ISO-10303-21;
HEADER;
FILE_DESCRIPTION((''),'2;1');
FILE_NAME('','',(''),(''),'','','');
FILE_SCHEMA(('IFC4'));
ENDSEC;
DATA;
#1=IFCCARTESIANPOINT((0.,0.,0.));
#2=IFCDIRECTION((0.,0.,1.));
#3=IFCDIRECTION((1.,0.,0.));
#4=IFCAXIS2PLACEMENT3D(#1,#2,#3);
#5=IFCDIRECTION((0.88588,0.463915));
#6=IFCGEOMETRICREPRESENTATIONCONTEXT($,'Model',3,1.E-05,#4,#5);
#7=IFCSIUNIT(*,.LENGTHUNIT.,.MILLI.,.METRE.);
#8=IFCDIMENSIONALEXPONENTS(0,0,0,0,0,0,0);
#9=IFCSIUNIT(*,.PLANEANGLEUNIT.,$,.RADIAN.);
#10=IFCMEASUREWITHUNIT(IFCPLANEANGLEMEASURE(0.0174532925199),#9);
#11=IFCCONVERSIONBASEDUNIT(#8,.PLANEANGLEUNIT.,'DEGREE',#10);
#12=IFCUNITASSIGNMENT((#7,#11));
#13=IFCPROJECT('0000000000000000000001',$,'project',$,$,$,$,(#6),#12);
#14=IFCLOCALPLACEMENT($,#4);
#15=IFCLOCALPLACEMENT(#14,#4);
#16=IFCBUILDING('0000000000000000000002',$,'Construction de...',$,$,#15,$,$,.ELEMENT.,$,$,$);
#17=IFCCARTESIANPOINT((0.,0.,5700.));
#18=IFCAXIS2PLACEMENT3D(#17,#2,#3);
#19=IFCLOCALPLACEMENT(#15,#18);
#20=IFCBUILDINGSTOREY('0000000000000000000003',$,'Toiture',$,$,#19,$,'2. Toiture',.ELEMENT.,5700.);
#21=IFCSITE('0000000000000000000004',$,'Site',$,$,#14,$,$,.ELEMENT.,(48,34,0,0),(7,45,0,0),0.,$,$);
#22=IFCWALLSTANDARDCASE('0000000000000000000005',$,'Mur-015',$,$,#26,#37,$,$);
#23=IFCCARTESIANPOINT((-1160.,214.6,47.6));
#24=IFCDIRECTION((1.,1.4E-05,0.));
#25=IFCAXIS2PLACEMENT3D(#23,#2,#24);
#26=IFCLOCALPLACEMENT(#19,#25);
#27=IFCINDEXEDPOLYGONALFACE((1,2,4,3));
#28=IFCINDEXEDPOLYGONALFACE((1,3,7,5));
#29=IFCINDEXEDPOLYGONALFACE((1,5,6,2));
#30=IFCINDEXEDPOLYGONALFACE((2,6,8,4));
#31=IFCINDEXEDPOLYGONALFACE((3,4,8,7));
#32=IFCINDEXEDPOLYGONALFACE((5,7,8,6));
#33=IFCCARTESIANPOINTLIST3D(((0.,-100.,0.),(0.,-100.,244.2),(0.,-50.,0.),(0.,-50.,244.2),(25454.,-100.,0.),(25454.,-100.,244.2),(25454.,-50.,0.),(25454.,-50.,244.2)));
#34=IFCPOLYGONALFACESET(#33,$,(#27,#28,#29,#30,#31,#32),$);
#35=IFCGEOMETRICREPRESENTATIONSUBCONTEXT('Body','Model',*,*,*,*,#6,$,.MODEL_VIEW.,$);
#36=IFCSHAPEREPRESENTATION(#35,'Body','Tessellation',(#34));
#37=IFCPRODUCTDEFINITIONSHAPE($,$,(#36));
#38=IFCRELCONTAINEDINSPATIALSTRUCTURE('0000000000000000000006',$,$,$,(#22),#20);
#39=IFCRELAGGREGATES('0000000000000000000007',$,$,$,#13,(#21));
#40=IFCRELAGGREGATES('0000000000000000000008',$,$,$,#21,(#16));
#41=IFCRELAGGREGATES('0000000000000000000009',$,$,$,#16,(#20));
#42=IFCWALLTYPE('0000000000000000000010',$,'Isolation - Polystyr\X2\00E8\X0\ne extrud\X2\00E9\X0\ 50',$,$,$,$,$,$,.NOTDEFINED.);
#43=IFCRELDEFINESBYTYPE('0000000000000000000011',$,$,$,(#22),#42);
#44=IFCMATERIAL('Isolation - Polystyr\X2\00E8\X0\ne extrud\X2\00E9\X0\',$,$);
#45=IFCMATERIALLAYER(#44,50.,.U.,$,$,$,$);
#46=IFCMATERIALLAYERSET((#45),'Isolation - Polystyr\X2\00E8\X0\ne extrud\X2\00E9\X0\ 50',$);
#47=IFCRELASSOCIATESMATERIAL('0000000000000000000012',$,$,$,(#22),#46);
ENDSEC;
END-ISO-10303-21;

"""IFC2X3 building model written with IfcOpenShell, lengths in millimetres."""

from ifc_helpers import new_model, entity, si_unit, converted_unit, direction, frame, origin_with_axes, place, context, subcontext, project, spatial, polyline, outline, extrude, material, layer, layer_set, layer_usage, type_object, element, save


model = new_model("IFC2X3")

# Units and contexts
model_context = context("Model", 3, precision=1e-05, world=origin_with_axes(), true_north=direction((0.88588, 0.463915)))
body_context = subcontext(model_context, "Body", "Model", "MODEL_VIEW")
ifc_project = project(units=[si_unit("LENGTHUNIT", "METRE", prefix="MILLI"), converted_unit("PLANEANGLEUNIT", "DEGREE", entity("IfcPlaneAngleMeasure", 0.0174532925199), si_unit("PLANEANGLEUNIT", "RADIAN"), dimensions=[0, 0, 0, 0, 0, 0, 0])], contexts=[model_context])

# Site, building, storey
site_placement = place(None, origin_with_axes())
site = spatial("IfcSite", under=ifc_project, at=site_placement, Name="Site", CompositionType="ELEMENT", RefLatitude=(48, 34, 0, 0), RefLongitude=(7, 45, 0, 0), RefElevation=0.0)
building_placement = place(site_placement, origin_with_axes())
building = spatial("IfcBuilding", under=site, at=building_placement, Name="Construction de...", CompositionType="ELEMENT")
storey_placement = place(building_placement, frame((0.0, 0.0, 5700.0), z_axis=(0.0, 0.0, 1.0), x_axis=(1.0, 0.0, 0.0)))
storey = spatial("IfcBuildingStorey", under=building, at=storey_placement, Name="Toiture", LongName="2. Toiture", CompositionType="ELEMENT", Elevation=5700.0)

# Wall
ifc_material = material(Name="Isolation - Polystyrène extrudé")
ifc_layer = layer(ifc_material, 50.0, ventilated="UNKNOWN")
ifc_layer_set = layer_set([ifc_layer], Name="Isolation - Polystyrène extrudé 50")
ifc_layer_usage = layer_usage(ifc_layer_set, "AXIS2", "POSITIVE", -100.0)
wall_type = type_object("IfcWallType", Name="Isolation - Polystyrène extrudé 50", PredefinedType="NOTDEFINED")
wall_placement = place(storey_placement, frame((-1160.0, 214.6, 47.6), z_axis=(0.0, 0.0, 1.0), x_axis=(1.0, 0.000014, 0.0)))
element("IfcWallStandardCase", 1, at=wall_placement, inside=storey, type_object=wall_type, material=ifc_layer_usage, Name="Mur-015", context=body_context, shape_type="SweptSolid", body=[
    extrude(outline(polyline([(0.0, -100.0), (25454.0, -100.0), (25454.0, -50.0), (0.0, -50.0), (0.0, -100.0)])), origin_with_axes(), (0.0, 0.0, 1.0), 244.2),
])

save(model, "model.ifc")
